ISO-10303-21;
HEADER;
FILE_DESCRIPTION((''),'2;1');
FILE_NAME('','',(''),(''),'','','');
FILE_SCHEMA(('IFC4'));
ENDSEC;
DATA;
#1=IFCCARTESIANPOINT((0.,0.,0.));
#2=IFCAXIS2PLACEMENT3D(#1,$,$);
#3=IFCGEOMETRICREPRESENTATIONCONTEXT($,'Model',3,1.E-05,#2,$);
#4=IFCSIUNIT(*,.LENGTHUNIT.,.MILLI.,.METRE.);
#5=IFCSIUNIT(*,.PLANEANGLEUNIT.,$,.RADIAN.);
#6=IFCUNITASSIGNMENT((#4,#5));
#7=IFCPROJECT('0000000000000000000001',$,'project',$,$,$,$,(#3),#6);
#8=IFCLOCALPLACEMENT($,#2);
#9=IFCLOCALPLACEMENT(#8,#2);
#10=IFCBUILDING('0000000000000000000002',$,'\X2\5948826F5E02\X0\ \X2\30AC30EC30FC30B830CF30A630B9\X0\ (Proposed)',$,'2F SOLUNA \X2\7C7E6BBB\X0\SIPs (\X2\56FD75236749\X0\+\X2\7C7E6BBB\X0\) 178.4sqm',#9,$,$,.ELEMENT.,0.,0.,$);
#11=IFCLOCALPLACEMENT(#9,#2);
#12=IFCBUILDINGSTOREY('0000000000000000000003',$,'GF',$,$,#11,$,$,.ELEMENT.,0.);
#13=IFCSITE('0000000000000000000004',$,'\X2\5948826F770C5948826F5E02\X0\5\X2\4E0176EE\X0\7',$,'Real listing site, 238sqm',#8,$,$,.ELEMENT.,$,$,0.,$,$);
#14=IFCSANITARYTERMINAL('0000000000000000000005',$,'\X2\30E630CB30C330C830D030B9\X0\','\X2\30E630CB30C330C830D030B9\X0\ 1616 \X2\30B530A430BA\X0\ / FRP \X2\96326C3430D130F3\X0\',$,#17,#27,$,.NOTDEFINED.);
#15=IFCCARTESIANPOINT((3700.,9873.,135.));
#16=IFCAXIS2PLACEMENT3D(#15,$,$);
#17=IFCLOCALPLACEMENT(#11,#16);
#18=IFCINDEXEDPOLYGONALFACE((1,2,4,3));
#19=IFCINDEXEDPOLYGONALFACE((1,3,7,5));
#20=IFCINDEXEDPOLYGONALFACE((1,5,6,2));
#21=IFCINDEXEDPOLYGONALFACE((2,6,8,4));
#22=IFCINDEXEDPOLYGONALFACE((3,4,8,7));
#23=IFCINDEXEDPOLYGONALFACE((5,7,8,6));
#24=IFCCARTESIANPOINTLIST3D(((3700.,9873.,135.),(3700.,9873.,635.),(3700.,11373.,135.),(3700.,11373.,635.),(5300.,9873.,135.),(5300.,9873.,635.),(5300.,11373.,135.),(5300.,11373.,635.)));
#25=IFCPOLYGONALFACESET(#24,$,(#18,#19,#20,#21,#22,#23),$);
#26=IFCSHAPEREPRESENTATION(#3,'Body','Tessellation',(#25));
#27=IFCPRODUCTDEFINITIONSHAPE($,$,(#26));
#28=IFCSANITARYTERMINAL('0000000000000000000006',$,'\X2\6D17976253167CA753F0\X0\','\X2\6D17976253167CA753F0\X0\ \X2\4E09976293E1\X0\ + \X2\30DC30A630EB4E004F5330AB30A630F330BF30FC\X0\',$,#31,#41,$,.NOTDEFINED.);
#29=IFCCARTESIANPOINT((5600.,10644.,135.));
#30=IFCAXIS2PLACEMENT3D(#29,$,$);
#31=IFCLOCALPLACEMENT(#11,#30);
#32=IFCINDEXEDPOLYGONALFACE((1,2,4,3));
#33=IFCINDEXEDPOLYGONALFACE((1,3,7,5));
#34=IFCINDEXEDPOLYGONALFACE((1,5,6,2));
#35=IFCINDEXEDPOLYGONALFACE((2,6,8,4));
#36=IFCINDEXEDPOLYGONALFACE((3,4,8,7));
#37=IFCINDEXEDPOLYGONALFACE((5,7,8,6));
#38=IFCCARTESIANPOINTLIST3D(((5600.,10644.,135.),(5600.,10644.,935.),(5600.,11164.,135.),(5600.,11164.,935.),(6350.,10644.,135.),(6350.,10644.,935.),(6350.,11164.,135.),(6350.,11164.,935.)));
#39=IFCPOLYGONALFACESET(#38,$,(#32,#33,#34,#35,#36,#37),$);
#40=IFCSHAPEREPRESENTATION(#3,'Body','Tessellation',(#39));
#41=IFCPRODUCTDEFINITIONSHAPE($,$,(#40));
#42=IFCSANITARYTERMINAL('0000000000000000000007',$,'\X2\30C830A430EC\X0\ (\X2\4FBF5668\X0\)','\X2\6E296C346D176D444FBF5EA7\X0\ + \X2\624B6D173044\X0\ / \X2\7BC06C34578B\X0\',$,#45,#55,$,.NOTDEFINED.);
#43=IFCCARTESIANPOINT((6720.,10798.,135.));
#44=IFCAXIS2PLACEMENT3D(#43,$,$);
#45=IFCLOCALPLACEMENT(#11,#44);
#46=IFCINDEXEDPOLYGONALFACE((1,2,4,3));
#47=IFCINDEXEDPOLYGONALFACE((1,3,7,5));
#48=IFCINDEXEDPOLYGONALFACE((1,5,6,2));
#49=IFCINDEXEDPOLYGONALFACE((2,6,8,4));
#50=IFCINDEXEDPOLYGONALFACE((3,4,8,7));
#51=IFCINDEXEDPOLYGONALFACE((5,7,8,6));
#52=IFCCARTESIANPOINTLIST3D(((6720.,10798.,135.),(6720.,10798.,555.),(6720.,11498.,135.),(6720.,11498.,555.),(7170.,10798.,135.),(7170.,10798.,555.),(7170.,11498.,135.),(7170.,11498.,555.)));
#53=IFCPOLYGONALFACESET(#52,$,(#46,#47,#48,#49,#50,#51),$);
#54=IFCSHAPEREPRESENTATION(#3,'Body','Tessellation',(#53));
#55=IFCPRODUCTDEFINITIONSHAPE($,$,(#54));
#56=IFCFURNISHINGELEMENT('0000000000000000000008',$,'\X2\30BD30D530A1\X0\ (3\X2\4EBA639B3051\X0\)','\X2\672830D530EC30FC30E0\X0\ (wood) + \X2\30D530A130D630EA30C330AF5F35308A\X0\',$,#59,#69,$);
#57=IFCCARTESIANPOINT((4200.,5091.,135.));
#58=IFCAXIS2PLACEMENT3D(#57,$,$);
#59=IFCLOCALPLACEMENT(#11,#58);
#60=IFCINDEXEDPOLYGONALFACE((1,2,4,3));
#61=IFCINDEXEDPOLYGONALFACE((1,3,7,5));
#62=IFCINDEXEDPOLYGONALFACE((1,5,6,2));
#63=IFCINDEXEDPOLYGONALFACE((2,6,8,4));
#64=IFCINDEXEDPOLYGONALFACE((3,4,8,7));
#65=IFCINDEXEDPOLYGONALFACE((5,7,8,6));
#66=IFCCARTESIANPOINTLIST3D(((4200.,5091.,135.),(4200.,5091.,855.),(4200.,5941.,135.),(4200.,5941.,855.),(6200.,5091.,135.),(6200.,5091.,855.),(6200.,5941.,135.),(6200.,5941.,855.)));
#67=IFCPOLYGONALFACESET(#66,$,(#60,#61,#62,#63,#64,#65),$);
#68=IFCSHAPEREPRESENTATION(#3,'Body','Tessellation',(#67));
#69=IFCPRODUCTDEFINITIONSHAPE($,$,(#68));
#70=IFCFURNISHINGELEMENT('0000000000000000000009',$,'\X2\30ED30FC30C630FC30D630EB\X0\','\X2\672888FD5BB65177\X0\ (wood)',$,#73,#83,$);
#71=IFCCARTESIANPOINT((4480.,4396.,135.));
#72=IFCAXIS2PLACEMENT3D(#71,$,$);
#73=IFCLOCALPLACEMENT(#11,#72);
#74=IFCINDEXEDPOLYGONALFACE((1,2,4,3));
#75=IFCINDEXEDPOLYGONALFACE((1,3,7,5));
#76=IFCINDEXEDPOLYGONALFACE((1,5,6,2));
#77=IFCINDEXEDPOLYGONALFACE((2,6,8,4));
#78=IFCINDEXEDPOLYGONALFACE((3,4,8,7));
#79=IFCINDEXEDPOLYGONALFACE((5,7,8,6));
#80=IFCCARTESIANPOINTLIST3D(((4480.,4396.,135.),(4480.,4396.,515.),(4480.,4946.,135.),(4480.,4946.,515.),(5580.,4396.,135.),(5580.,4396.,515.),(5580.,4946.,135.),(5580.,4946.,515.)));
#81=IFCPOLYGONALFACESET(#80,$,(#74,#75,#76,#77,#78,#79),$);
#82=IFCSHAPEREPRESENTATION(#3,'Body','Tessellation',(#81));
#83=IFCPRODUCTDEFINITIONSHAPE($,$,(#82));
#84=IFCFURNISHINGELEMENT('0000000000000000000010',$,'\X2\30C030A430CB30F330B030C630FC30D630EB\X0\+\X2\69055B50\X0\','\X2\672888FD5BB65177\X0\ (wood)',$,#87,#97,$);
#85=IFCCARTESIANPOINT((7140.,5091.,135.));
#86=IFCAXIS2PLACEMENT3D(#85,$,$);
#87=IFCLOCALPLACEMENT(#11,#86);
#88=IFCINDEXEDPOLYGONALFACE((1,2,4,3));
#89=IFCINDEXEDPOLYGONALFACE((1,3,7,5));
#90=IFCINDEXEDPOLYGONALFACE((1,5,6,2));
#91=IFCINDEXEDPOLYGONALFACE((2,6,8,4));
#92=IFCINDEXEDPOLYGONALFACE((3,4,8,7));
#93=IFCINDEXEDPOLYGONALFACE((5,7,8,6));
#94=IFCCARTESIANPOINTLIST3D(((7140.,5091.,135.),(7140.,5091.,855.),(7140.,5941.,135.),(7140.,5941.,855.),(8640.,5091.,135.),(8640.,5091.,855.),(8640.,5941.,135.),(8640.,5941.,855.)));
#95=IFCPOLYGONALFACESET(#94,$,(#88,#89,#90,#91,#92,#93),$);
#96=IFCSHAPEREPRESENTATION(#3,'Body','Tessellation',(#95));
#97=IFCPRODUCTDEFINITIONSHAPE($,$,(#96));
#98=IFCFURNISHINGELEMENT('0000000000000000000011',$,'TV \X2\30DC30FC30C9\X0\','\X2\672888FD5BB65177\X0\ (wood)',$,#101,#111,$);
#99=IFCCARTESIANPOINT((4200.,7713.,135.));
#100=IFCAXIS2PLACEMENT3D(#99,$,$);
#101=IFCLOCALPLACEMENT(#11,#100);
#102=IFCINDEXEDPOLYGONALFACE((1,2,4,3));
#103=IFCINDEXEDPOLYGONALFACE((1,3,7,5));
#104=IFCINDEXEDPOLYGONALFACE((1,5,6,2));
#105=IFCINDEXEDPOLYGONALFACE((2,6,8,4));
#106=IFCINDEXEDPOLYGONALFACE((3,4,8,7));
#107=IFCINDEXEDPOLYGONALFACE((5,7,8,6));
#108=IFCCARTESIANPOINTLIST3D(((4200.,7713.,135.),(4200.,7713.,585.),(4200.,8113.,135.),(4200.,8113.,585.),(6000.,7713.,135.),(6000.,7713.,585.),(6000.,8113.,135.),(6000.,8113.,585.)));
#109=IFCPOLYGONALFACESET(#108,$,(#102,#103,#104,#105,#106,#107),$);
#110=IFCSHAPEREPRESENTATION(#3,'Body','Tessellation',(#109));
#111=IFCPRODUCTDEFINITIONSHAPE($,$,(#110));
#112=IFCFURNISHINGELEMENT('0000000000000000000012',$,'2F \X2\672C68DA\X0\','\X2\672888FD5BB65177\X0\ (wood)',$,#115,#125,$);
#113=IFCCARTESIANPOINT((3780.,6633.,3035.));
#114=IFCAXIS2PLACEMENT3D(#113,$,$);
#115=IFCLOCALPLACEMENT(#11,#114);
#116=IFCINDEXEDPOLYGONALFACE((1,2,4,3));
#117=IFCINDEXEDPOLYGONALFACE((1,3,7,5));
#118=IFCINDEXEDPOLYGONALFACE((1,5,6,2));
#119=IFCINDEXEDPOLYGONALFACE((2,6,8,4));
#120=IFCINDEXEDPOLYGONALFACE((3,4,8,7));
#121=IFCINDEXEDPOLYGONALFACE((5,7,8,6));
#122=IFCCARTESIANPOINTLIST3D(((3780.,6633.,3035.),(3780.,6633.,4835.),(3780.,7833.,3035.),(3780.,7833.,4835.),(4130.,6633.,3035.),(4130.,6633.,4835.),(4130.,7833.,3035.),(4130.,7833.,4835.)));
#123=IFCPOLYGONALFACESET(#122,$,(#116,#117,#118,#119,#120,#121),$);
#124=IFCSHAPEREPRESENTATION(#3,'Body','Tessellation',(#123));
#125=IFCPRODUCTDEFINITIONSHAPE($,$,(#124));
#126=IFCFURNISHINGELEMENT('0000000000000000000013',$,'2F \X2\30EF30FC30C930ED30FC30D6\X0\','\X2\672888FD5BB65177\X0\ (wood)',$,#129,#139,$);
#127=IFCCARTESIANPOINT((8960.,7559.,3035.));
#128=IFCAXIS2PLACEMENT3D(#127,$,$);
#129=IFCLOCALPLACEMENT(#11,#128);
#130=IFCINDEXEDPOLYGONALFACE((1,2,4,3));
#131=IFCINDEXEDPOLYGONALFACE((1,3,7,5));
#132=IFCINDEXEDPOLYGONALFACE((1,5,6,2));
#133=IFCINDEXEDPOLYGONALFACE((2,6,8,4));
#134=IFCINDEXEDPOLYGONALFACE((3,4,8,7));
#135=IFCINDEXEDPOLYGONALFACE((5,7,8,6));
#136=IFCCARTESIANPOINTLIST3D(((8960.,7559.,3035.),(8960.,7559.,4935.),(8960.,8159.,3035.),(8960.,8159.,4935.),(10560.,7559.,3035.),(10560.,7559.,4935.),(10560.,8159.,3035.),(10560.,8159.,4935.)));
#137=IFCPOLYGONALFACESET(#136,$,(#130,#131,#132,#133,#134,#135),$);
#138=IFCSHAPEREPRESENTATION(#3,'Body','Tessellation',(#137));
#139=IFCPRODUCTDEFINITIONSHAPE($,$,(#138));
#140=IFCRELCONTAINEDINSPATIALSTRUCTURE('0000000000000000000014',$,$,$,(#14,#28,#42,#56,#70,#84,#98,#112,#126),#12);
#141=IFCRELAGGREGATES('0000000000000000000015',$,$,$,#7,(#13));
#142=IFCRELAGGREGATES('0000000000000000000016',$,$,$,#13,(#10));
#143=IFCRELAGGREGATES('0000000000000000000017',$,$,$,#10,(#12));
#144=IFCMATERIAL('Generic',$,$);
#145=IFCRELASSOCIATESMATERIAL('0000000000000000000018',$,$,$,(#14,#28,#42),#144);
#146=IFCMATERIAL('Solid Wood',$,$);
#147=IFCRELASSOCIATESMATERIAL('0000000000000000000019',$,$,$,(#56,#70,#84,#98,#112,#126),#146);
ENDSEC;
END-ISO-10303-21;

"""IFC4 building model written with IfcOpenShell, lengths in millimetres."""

from ifc_helpers import new_model, si_unit, frame, frame_2d, origin, place, context, project, spatial, rectangle, extrude, material, element, save


model = new_model("IFC4")

# Units and contexts
model_context = context("Model", 3, precision=1e-05, world=origin())
ifc_project = project(units=[si_unit("LENGTHUNIT", "METRE", prefix="MILLI"), si_unit("PLANEANGLEUNIT", "RADIAN")], contexts=[model_context])

# Site, building, storey
site_placement = place(None, origin())
site = spatial("IfcSite", under=ifc_project, at=site_placement, Name="奈良県奈良市5丁目7", ObjectType="Real listing site, 238sqm", CompositionType="ELEMENT", RefElevation=0.0)
building_placement = place(site_placement, origin())
building = spatial("IfcBuilding", under=site, at=building_placement, Name="奈良市 ガレージハウス (Proposed)", ObjectType="2F SOLUNA 籾殻SIPs (国産杉+籾殻) 178.4sqm", CompositionType="ELEMENT", ElevationOfRefHeight=0.0, ElevationOfTerrain=0.0)
storey_placement = place(building_placement, origin())
storey = spatial("IfcBuildingStorey", under=building, at=storey_placement, Name="GF", CompositionType="ELEMENT", Elevation=0.0)

# Shared definitions
ifc_material_1 = material(Name="Generic")

# Shared definitions
ifc_material_2 = material(Name="Solid Wood")

# Sanitary terminals
sanitary_terminal_1_placement = place(storey_placement, frame((3700.0, 9873.0, 135.0)))
element("IfcSanitaryTerminal", 1, at=sanitary_terminal_1_placement, inside=storey, material=ifc_material_1, Name="ユニットバス", Description="ユニットバス 1616 サイズ / FRP 防水パン", PredefinedType="NOTDEFINED", context=model_context, shape_type="SweptSolid", body=[
    extrude(rectangle(XDim=1600.0, YDim=1500.0, at=frame_2d((800.0, 750.0))), frame((3700.0, 9873.0, 135.0)), (0.0, 0.0, 1.0), 500.0),
])
sanitary_terminal_2_placement = place(storey_placement, frame((5600.0, 10644.0, 135.0)))
element("IfcSanitaryTerminal", 2, at=sanitary_terminal_2_placement, inside=storey, material=ifc_material_1, Name="洗面化粧台", Description="洗面化粧台 三面鏡 + ボウル一体カウンター", PredefinedType="NOTDEFINED", context=model_context, shape_type="SweptSolid", body=[
    extrude(rectangle(XDim=750.0, YDim=520.0, at=frame_2d((375.0, 260.0))), frame((5600.0, 10644.0, 135.0)), (0.0, 0.0, 1.0), 800.0),
])
sanitary_terminal_3_placement = place(storey_placement, frame((6720.0, 10798.0, 135.0)))
element("IfcSanitaryTerminal", 3, at=sanitary_terminal_3_placement, inside=storey, material=ifc_material_1, Name="トイレ (便器)", Description="温水洗浄便座 + 手洗い / 節水型", PredefinedType="NOTDEFINED", context=model_context, shape_type="SweptSolid", body=[
    extrude(rectangle(XDim=450.0, YDim=700.0, at=frame_2d((225.0, 350.0))), frame((6720.0, 10798.0, 135.0)), (0.0, 0.0, 1.0), 420.0),
])

# Furnishing elements
furnishing_1_placement = place(storey_placement, frame((4200.0, 5091.0, 135.0)))
element("IfcFurnishingElement", 4, at=furnishing_1_placement, inside=storey, material=ifc_material_2, Name="ソファ (3人掛け)", Description="木フレーム (wood) + ファブリック張り", context=model_context, shape_type="SweptSolid", body=[
    extrude(rectangle(XDim=2000.0, YDim=850.0, at=frame_2d((1000.0, 425.0))), frame((4200.0, 5091.0, 135.0)), (0.0, 0.0, 1.0), 720.0),
])
furnishing_2_placement = place(storey_placement, frame((4480.0, 4396.0, 135.0)))
element("IfcFurnishingElement", 5, at=furnishing_2_placement, inside=storey, material=ifc_material_2, Name="ローテーブル", Description="木製家具 (wood)", context=model_context, shape_type="SweptSolid", body=[
    extrude(rectangle(XDim=1100.0, YDim=550.0, at=frame_2d((550.0, 275.0))), frame((4480.0, 4396.0, 135.0)), (0.0, 0.0, 1.0), 380.0),
])
furnishing_3_placement = place(storey_placement, frame((7140.0, 5091.0, 135.0)))
element("IfcFurnishingElement", 6, at=furnishing_3_placement, inside=storey, material=ifc_material_2, Name="ダイニングテーブル+椅子", Description="木製家具 (wood)", context=model_context, shape_type="SweptSolid", body=[
    extrude(rectangle(XDim=1500.0, YDim=850.0, at=frame_2d((750.0, 425.0))), frame((7140.0, 5091.0, 135.0)), (0.0, 0.0, 1.0), 720.0),
])
furnishing_4_placement = place(storey_placement, frame((4200.0, 7713.0, 135.0)))
element("IfcFurnishingElement", 7, at=furnishing_4_placement, inside=storey, material=ifc_material_2, Name="TV ボード", Description="木製家具 (wood)", context=model_context, shape_type="SweptSolid", body=[
    extrude(rectangle(XDim=1800.0, YDim=400.0, at=frame_2d((900.0, 200.0))), frame((4200.0, 7713.0, 135.0)), (0.0, 0.0, 1.0), 450.0),
])
furnishing_5_placement = place(storey_placement, frame((3780.0, 6633.0, 3035.0)))
element("IfcFurnishingElement", 8, at=furnishing_5_placement, inside=storey, material=ifc_material_2, Name="2F 本棚", Description="木製家具 (wood)", context=model_context, shape_type="SweptSolid", body=[
    extrude(rectangle(XDim=350.0, YDim=1200.0, at=frame_2d((175.0, 600.0))), frame((3780.0, 6633.0, 3035.0)), (0.0, 0.0, 1.0), 1800.0),
])
furnishing_6_placement = place(storey_placement, frame((8960.0, 7559.0, 3035.0)))
element("IfcFurnishingElement", 9, at=furnishing_6_placement, inside=storey, material=ifc_material_2, Name="2F ワードローブ", Description="木製家具 (wood)", context=model_context, shape_type="SweptSolid", body=[
    extrude(rectangle(XDim=1600.0, YDim=600.0, at=frame_2d((800.0, 300.0))), frame((8960.0, 7559.0, 3035.0)), (0.0, 0.0, 1.0), 1900.0),
])

save(model, "model.ifc")
